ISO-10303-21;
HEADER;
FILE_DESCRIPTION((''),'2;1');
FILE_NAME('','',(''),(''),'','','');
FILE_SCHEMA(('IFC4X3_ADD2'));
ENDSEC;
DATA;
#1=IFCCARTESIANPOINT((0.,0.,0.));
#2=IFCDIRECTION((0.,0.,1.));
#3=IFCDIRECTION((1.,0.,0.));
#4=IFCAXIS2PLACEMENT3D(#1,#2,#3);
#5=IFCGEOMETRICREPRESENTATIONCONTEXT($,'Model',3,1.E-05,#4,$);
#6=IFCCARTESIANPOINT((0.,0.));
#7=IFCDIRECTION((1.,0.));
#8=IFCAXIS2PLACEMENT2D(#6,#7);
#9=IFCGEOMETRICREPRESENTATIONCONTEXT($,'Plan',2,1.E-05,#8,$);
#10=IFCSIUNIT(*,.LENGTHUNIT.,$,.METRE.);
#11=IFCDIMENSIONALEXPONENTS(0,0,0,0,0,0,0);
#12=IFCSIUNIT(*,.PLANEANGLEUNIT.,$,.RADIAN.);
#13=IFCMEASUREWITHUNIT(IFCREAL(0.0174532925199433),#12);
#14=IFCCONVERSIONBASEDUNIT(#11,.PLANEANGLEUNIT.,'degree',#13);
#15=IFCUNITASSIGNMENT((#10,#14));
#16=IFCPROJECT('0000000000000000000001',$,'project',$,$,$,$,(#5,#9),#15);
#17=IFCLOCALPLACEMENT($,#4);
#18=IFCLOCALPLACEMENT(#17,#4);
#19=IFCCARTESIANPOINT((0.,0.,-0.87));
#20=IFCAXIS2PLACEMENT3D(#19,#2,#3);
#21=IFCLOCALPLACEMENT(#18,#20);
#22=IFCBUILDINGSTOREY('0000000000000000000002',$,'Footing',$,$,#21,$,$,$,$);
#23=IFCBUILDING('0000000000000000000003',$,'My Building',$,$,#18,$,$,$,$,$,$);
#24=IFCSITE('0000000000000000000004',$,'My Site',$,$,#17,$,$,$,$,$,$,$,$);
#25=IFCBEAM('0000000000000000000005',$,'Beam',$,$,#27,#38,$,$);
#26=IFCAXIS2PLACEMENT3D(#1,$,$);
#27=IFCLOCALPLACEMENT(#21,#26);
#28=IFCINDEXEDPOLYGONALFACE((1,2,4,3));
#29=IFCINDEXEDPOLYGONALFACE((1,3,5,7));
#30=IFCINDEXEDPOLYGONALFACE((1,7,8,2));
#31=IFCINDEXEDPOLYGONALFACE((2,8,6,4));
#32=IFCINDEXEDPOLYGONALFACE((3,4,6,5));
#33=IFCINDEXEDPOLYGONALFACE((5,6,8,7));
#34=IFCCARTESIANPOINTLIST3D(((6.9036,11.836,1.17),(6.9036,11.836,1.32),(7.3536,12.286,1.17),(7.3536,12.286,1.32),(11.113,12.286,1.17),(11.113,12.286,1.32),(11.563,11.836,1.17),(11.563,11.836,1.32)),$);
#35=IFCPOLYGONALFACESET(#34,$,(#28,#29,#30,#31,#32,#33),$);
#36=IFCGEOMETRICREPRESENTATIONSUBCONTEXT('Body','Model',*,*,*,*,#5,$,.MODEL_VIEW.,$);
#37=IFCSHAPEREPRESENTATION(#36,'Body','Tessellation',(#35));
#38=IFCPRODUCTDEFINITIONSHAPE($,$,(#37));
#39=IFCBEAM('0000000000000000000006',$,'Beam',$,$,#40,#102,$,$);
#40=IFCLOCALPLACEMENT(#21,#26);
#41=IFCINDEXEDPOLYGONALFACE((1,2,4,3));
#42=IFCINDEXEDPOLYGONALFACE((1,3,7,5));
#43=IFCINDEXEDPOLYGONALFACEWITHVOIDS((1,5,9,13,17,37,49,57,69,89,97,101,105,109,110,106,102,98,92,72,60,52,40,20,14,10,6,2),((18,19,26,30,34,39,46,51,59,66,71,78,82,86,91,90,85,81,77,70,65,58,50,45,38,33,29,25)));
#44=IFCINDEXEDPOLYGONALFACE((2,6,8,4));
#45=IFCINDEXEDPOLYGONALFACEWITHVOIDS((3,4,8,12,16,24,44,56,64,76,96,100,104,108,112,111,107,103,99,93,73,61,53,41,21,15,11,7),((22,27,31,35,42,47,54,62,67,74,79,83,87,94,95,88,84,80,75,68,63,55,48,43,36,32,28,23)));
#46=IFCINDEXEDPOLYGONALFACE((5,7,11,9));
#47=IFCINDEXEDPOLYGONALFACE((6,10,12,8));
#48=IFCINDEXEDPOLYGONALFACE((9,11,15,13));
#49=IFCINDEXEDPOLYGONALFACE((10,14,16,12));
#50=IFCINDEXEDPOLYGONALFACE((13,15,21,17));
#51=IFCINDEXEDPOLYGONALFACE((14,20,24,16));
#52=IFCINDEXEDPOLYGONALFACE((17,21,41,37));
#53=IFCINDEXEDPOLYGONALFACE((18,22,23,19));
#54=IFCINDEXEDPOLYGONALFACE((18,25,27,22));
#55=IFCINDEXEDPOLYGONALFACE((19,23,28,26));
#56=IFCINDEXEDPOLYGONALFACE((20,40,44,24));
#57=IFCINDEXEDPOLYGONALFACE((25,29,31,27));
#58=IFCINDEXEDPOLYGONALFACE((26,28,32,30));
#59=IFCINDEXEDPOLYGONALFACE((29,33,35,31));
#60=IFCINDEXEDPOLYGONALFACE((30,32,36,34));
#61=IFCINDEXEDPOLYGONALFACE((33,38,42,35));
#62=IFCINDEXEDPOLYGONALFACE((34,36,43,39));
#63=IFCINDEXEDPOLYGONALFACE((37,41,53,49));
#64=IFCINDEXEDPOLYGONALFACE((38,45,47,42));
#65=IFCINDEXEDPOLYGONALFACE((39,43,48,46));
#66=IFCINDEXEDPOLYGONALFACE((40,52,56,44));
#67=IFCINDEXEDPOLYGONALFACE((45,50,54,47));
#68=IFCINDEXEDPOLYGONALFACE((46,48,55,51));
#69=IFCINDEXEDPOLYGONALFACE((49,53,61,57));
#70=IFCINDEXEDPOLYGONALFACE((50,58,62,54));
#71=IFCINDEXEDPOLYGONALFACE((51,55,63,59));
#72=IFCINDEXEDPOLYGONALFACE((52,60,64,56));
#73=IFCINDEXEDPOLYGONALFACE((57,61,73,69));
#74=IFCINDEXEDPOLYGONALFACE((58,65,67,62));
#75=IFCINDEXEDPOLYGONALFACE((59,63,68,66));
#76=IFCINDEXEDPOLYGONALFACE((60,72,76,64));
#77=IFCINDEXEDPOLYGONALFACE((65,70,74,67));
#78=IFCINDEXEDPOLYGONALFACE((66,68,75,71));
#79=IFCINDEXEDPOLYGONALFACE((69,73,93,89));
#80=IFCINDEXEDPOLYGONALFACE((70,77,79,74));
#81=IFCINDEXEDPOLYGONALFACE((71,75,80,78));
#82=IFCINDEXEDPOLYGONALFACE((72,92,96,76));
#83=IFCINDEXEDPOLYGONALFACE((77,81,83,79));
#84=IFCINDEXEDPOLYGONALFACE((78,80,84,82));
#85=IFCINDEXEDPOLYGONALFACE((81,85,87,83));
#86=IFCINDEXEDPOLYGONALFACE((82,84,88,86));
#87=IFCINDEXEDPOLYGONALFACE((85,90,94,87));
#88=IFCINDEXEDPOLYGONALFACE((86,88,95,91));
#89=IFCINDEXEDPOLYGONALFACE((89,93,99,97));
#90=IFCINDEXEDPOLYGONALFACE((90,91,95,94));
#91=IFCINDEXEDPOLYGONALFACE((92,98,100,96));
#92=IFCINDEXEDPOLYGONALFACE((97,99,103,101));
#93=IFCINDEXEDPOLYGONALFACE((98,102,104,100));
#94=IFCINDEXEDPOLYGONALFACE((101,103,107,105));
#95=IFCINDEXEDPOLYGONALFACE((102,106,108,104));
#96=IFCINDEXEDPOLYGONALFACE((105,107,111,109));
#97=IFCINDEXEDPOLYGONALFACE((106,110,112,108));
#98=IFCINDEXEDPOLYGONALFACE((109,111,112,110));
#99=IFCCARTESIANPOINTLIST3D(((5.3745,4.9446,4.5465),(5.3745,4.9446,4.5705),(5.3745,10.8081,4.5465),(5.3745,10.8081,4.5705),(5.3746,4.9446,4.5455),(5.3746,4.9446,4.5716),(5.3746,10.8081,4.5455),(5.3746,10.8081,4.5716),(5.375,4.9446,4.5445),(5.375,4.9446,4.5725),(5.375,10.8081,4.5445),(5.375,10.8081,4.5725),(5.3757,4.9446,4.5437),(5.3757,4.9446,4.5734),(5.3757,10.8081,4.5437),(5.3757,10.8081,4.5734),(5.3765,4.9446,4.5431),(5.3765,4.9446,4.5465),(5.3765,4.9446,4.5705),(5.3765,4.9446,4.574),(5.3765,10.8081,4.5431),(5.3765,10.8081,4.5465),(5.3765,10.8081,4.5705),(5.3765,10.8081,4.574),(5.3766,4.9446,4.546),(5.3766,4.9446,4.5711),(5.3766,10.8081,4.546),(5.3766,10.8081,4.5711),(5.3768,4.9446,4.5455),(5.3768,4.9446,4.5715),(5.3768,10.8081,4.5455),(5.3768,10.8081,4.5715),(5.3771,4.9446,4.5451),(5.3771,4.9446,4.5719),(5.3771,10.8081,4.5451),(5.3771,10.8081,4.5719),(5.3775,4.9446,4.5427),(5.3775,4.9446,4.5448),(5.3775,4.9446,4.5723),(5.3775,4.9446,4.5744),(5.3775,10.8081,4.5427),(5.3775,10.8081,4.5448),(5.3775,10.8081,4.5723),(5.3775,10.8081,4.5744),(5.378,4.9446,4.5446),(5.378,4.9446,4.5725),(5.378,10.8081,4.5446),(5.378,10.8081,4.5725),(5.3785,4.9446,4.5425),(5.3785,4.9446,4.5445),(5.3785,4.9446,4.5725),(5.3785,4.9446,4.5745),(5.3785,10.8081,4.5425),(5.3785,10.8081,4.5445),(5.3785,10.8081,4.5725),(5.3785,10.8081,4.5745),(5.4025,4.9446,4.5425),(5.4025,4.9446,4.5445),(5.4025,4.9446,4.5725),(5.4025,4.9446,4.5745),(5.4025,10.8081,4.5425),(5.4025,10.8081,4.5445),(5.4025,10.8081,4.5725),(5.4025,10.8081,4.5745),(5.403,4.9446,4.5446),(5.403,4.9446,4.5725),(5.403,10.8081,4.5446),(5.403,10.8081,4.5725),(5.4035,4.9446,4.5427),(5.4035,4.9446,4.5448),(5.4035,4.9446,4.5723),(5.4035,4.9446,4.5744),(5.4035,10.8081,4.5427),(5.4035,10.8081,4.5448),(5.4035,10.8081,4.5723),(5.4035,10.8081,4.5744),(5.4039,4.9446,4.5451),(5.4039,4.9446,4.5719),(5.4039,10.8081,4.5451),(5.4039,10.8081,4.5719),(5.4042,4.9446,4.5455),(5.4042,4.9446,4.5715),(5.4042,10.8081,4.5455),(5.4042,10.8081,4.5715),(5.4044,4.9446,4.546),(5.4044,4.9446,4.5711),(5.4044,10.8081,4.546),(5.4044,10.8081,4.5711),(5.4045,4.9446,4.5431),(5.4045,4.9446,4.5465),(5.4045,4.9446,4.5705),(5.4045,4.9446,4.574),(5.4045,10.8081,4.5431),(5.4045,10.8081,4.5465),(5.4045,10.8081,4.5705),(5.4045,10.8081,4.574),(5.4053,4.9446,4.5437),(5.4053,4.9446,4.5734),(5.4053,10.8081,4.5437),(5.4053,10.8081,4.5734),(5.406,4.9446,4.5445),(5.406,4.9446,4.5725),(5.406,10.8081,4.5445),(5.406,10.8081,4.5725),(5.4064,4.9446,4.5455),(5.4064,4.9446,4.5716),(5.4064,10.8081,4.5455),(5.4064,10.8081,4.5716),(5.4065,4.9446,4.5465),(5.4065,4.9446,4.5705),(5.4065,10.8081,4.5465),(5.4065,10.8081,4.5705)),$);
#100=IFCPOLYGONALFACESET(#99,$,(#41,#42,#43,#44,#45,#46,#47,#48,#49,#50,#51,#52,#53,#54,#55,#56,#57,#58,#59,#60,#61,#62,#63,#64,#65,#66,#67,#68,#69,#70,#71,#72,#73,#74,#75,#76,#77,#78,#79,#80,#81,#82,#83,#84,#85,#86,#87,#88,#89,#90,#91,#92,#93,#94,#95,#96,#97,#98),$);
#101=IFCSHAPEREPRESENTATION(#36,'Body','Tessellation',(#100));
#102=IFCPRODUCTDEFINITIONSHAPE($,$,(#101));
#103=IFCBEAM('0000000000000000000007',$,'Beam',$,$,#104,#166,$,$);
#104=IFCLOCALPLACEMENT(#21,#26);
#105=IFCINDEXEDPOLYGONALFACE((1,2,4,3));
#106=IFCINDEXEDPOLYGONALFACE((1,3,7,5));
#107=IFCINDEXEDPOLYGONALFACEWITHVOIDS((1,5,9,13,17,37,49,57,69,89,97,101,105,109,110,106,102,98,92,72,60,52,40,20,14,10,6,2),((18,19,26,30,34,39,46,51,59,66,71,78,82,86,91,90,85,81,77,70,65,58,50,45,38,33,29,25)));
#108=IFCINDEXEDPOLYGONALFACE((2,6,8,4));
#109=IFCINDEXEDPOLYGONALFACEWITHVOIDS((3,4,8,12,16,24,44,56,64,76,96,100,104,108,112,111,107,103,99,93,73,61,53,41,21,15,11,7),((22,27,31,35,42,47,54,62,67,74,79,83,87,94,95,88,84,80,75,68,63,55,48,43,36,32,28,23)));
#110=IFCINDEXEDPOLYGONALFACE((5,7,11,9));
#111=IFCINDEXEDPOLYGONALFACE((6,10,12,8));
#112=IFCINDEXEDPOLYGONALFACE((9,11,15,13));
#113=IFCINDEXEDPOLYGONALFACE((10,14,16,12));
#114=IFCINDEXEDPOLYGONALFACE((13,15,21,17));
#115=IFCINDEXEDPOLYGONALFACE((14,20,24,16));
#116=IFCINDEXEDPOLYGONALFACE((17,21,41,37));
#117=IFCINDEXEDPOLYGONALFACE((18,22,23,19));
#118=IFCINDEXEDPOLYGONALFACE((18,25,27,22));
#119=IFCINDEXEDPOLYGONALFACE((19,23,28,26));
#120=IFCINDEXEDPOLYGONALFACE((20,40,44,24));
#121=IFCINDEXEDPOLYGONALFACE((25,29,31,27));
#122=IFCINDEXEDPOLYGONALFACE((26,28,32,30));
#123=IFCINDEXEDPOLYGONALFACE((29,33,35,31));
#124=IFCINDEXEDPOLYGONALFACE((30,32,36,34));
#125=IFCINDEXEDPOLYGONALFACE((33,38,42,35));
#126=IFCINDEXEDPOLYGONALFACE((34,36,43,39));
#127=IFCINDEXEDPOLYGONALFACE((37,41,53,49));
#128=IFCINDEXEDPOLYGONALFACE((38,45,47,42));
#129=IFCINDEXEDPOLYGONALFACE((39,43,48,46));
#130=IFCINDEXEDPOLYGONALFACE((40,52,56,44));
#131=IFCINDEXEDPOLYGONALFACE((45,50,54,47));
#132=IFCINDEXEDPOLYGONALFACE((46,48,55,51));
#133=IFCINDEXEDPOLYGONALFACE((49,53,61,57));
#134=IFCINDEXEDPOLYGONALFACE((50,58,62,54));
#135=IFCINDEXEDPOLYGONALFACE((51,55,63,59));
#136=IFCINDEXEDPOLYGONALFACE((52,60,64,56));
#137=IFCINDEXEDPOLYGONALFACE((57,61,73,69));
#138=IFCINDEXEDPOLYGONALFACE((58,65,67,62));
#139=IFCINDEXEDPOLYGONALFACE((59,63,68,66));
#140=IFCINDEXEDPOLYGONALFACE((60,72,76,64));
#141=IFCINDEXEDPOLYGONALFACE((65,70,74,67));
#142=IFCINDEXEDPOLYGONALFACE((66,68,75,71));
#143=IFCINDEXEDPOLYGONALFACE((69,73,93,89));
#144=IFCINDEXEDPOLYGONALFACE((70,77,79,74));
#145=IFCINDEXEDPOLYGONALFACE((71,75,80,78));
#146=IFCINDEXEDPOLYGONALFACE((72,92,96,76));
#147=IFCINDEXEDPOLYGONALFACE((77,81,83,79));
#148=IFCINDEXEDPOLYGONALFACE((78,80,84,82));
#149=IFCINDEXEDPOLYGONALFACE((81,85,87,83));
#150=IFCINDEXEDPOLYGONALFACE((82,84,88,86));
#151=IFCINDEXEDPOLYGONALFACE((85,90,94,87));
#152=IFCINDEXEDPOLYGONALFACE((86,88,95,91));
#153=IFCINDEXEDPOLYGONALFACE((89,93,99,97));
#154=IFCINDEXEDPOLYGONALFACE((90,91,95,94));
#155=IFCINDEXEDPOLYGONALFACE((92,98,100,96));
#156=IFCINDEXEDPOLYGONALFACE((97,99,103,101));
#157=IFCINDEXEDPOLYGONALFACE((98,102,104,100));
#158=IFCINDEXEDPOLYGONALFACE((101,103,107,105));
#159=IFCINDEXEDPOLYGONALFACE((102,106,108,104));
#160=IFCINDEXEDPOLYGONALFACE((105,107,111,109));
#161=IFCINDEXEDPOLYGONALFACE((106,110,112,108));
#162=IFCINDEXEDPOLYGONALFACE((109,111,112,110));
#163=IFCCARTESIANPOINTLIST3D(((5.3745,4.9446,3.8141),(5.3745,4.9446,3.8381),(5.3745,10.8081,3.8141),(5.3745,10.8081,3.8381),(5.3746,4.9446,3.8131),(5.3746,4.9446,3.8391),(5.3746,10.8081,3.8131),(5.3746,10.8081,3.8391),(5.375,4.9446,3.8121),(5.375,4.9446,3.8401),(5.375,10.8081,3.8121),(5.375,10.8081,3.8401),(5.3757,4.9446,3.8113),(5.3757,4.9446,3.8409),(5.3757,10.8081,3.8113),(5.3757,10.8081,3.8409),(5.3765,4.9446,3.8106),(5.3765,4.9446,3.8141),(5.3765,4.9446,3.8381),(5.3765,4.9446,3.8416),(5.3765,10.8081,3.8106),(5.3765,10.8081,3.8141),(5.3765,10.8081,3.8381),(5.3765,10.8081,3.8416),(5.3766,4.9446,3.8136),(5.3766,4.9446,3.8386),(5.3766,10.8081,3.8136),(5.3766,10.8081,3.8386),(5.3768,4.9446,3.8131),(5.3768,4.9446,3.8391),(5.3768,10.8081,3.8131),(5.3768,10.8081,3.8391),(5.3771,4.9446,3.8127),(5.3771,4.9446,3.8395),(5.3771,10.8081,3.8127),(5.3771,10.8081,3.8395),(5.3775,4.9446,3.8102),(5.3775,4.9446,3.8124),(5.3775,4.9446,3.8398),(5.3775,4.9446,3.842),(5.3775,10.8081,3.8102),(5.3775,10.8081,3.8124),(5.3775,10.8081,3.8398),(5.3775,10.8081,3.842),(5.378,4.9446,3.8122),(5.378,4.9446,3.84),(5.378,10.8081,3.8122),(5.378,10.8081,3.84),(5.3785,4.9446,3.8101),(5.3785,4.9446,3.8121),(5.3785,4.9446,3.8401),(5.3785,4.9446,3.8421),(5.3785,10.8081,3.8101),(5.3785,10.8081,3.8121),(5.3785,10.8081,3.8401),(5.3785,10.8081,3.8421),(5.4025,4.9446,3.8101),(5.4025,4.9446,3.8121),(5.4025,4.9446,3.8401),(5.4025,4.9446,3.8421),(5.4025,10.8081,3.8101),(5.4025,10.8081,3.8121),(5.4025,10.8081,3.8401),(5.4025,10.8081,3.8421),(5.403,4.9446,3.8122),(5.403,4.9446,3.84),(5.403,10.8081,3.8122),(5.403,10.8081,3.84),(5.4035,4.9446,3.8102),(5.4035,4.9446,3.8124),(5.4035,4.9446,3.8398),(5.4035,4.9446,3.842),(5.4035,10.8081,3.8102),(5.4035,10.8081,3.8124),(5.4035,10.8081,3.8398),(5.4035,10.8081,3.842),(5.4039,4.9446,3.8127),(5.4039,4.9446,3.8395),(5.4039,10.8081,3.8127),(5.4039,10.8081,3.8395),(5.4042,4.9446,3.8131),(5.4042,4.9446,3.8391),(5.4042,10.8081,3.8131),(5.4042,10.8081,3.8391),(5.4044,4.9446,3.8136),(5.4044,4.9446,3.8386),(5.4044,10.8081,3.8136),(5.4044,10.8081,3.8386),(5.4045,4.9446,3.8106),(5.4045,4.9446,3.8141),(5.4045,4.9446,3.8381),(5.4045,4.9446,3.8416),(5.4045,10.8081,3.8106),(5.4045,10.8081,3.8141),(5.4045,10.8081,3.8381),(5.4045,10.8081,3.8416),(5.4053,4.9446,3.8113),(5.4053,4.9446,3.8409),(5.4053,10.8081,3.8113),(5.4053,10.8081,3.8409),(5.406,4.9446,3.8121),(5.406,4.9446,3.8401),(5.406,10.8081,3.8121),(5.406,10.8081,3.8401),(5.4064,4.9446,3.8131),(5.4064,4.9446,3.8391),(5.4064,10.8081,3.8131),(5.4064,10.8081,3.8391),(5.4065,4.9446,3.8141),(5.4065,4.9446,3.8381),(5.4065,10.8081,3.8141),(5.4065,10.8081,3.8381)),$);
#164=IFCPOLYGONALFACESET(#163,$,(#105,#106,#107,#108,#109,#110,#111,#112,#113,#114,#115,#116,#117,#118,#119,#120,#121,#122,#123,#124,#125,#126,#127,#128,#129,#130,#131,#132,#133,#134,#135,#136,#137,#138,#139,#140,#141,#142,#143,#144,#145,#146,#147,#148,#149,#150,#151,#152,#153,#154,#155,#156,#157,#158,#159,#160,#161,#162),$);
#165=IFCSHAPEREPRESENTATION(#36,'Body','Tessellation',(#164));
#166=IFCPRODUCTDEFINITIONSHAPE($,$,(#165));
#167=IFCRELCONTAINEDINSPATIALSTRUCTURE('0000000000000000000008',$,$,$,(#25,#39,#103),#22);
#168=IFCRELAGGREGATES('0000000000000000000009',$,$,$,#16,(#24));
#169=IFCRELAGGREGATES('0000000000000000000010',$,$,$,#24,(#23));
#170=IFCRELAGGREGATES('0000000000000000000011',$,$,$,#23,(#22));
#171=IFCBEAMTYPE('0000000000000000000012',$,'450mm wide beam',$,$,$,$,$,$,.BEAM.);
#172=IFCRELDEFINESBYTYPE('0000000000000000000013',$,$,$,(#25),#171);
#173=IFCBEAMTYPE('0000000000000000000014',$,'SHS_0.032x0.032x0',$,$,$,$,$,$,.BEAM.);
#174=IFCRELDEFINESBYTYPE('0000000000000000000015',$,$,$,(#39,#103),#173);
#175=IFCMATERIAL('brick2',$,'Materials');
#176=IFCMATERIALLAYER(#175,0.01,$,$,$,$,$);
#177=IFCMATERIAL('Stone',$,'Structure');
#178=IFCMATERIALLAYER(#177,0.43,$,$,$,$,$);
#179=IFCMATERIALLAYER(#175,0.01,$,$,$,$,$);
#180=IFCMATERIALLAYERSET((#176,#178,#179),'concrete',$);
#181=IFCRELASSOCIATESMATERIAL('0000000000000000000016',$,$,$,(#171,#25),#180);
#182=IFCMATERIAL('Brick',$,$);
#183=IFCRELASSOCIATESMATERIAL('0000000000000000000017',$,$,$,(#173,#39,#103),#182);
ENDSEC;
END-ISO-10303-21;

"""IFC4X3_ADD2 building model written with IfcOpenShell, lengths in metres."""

from ifc_helpers import new_model, entity, si_unit, converted_unit, frame, origin_with_axes, origin_2d_with_axis, place, context, subcontext, project, spatial, line, indexed_curve, hollow_rectangle, outline, extrude, material, layer, layer_set, layer_usage, material_profile, profile_set, profile_usage, type_object, element, save


model = new_model("IFC4X3_ADD2")

# Units and contexts
model_context = context("Model", 3, precision=1e-05, world=origin_with_axes())
plan_context = context("Plan", 2, precision=1e-05, world=origin_2d_with_axis())
body_context = subcontext(model_context, "Body", "Model", "MODEL_VIEW")
ifc_project = project(units=[si_unit("LENGTHUNIT", "METRE"), converted_unit("PLANEANGLEUNIT", "degree", entity("IfcReal", 0.0174532925199433), si_unit("PLANEANGLEUNIT", "RADIAN"), dimensions=[0, 0, 0, 0, 0, 0, 0])], contexts=[model_context, plan_context])

# Site, building, storey
site_placement = place(None, origin_with_axes())
site = spatial("IfcSite", under=ifc_project, at=site_placement, Name="My Site")
building_placement = place(site_placement, origin_with_axes())
building = spatial("IfcBuilding", under=site, at=building_placement, Name="My Building")
storey_placement = place(building_placement, frame((0.0, 0.0, -0.87), z_axis=(0.0, 0.0, 1.0), x_axis=(1.0, 0.0, 0.0)))
storey = spatial("IfcBuildingStorey", under=building, at=storey_placement, Name="Footing")

# Beams
ifc_material_1 = material(Name="brick2", Category="Materials")
ifc_layer_1 = layer(ifc_material_1, 0.01)
ifc_material_2 = material(Name="Stone", Category="Structure")
ifc_layer_2 = layer(ifc_material_2, 0.43)
ifc_layer_3 = layer(ifc_material_1, 0.01)
ifc_layer_set_1 = layer_set([ifc_layer_1, ifc_layer_2, ifc_layer_3], Name="concrete")
ifc_layer_usage_1 = layer_usage(ifc_layer_set_1, "AXIS2", "POSITIVE", 0.0)
beam_type_1 = type_object("IfcBeamType", Name="450mm wide beam", PredefinedType="BEAM", material=ifc_layer_set_1)
beam_1_placement = place(storey_placement, frame((6.9036, 11.836, 1.17), z_axis=(0.0, 0.0, 1.0), x_axis=(1.0, 0.0, 0.0)))
element("IfcBeam", 1, at=beam_1_placement, inside=storey, type_object=beam_type_1, material=ifc_layer_usage_1, Name="Beam", context=body_context, shape_type="SweptSolid", body=[
    extrude(outline(indexed_curve([(0.0, 0.0), (0.45, 0.45), (4.2094, 0.45), (4.6594, 0.0)], segments=[line(1, 2, 3, 4, 1)])), origin_with_axes(), (0.0, 0.0, 1.0), 0.15),
])
ifc_material_3 = material(Name="Brick")
ifc_material_profile = material_profile(ifc_material_3, hollow_rectangle(XDim=0.032, YDim=0.032, WallThickness=0.002, InnerFilletRadius=0.002, OuterFilletRadius=0.004))
ifc_profile_set = profile_set([ifc_material_profile])
ifc_profile_usage_1 = profile_usage(ifc_profile_set, cardinal=5)
beam_type_2 = type_object("IfcBeamType", Name="SHS_0.032x0.032x0", PredefinedType="BEAM", material=ifc_profile_set)
beam_2_placement = place(storey_placement, frame((5.3905, 4.9446, 4.5585), z_axis=(0.0, 1.0, 0.0), x_axis=(-1.0, 0.0, 0.0)))
element("IfcBeam", 2, at=beam_2_placement, inside=storey, type_object=beam_type_2, material=ifc_profile_usage_1, Name="Beam", context=body_context, shape_type="SweptSolid", body=[
    extrude(hollow_rectangle(XDim=0.032, YDim=0.032, WallThickness=0.002, InnerFilletRadius=0.002, OuterFilletRadius=0.004), origin_with_axes(), (0.0, 0.0, 1.0), 5.8635),
])
ifc_profile_usage_2 = profile_usage(ifc_profile_set, cardinal=5)
beam_3_placement = place(storey_placement, frame((5.3905, 4.9446, 3.8261), z_axis=(0.0, 1.0, 0.0), x_axis=(-1.0, 0.0, 0.0)))
element("IfcBeam", 3, at=beam_3_placement, inside=storey, type_object=beam_type_2, material=ifc_profile_usage_2, Name="Beam", context=body_context, shape_type="SweptSolid", body=[
    extrude(hollow_rectangle(XDim=0.032, YDim=0.032, WallThickness=0.002, InnerFilletRadius=0.002, OuterFilletRadius=0.004), origin_with_axes(), (0.0, 0.0, 1.0), 5.8635),
])

save(model, "model.ifc")
